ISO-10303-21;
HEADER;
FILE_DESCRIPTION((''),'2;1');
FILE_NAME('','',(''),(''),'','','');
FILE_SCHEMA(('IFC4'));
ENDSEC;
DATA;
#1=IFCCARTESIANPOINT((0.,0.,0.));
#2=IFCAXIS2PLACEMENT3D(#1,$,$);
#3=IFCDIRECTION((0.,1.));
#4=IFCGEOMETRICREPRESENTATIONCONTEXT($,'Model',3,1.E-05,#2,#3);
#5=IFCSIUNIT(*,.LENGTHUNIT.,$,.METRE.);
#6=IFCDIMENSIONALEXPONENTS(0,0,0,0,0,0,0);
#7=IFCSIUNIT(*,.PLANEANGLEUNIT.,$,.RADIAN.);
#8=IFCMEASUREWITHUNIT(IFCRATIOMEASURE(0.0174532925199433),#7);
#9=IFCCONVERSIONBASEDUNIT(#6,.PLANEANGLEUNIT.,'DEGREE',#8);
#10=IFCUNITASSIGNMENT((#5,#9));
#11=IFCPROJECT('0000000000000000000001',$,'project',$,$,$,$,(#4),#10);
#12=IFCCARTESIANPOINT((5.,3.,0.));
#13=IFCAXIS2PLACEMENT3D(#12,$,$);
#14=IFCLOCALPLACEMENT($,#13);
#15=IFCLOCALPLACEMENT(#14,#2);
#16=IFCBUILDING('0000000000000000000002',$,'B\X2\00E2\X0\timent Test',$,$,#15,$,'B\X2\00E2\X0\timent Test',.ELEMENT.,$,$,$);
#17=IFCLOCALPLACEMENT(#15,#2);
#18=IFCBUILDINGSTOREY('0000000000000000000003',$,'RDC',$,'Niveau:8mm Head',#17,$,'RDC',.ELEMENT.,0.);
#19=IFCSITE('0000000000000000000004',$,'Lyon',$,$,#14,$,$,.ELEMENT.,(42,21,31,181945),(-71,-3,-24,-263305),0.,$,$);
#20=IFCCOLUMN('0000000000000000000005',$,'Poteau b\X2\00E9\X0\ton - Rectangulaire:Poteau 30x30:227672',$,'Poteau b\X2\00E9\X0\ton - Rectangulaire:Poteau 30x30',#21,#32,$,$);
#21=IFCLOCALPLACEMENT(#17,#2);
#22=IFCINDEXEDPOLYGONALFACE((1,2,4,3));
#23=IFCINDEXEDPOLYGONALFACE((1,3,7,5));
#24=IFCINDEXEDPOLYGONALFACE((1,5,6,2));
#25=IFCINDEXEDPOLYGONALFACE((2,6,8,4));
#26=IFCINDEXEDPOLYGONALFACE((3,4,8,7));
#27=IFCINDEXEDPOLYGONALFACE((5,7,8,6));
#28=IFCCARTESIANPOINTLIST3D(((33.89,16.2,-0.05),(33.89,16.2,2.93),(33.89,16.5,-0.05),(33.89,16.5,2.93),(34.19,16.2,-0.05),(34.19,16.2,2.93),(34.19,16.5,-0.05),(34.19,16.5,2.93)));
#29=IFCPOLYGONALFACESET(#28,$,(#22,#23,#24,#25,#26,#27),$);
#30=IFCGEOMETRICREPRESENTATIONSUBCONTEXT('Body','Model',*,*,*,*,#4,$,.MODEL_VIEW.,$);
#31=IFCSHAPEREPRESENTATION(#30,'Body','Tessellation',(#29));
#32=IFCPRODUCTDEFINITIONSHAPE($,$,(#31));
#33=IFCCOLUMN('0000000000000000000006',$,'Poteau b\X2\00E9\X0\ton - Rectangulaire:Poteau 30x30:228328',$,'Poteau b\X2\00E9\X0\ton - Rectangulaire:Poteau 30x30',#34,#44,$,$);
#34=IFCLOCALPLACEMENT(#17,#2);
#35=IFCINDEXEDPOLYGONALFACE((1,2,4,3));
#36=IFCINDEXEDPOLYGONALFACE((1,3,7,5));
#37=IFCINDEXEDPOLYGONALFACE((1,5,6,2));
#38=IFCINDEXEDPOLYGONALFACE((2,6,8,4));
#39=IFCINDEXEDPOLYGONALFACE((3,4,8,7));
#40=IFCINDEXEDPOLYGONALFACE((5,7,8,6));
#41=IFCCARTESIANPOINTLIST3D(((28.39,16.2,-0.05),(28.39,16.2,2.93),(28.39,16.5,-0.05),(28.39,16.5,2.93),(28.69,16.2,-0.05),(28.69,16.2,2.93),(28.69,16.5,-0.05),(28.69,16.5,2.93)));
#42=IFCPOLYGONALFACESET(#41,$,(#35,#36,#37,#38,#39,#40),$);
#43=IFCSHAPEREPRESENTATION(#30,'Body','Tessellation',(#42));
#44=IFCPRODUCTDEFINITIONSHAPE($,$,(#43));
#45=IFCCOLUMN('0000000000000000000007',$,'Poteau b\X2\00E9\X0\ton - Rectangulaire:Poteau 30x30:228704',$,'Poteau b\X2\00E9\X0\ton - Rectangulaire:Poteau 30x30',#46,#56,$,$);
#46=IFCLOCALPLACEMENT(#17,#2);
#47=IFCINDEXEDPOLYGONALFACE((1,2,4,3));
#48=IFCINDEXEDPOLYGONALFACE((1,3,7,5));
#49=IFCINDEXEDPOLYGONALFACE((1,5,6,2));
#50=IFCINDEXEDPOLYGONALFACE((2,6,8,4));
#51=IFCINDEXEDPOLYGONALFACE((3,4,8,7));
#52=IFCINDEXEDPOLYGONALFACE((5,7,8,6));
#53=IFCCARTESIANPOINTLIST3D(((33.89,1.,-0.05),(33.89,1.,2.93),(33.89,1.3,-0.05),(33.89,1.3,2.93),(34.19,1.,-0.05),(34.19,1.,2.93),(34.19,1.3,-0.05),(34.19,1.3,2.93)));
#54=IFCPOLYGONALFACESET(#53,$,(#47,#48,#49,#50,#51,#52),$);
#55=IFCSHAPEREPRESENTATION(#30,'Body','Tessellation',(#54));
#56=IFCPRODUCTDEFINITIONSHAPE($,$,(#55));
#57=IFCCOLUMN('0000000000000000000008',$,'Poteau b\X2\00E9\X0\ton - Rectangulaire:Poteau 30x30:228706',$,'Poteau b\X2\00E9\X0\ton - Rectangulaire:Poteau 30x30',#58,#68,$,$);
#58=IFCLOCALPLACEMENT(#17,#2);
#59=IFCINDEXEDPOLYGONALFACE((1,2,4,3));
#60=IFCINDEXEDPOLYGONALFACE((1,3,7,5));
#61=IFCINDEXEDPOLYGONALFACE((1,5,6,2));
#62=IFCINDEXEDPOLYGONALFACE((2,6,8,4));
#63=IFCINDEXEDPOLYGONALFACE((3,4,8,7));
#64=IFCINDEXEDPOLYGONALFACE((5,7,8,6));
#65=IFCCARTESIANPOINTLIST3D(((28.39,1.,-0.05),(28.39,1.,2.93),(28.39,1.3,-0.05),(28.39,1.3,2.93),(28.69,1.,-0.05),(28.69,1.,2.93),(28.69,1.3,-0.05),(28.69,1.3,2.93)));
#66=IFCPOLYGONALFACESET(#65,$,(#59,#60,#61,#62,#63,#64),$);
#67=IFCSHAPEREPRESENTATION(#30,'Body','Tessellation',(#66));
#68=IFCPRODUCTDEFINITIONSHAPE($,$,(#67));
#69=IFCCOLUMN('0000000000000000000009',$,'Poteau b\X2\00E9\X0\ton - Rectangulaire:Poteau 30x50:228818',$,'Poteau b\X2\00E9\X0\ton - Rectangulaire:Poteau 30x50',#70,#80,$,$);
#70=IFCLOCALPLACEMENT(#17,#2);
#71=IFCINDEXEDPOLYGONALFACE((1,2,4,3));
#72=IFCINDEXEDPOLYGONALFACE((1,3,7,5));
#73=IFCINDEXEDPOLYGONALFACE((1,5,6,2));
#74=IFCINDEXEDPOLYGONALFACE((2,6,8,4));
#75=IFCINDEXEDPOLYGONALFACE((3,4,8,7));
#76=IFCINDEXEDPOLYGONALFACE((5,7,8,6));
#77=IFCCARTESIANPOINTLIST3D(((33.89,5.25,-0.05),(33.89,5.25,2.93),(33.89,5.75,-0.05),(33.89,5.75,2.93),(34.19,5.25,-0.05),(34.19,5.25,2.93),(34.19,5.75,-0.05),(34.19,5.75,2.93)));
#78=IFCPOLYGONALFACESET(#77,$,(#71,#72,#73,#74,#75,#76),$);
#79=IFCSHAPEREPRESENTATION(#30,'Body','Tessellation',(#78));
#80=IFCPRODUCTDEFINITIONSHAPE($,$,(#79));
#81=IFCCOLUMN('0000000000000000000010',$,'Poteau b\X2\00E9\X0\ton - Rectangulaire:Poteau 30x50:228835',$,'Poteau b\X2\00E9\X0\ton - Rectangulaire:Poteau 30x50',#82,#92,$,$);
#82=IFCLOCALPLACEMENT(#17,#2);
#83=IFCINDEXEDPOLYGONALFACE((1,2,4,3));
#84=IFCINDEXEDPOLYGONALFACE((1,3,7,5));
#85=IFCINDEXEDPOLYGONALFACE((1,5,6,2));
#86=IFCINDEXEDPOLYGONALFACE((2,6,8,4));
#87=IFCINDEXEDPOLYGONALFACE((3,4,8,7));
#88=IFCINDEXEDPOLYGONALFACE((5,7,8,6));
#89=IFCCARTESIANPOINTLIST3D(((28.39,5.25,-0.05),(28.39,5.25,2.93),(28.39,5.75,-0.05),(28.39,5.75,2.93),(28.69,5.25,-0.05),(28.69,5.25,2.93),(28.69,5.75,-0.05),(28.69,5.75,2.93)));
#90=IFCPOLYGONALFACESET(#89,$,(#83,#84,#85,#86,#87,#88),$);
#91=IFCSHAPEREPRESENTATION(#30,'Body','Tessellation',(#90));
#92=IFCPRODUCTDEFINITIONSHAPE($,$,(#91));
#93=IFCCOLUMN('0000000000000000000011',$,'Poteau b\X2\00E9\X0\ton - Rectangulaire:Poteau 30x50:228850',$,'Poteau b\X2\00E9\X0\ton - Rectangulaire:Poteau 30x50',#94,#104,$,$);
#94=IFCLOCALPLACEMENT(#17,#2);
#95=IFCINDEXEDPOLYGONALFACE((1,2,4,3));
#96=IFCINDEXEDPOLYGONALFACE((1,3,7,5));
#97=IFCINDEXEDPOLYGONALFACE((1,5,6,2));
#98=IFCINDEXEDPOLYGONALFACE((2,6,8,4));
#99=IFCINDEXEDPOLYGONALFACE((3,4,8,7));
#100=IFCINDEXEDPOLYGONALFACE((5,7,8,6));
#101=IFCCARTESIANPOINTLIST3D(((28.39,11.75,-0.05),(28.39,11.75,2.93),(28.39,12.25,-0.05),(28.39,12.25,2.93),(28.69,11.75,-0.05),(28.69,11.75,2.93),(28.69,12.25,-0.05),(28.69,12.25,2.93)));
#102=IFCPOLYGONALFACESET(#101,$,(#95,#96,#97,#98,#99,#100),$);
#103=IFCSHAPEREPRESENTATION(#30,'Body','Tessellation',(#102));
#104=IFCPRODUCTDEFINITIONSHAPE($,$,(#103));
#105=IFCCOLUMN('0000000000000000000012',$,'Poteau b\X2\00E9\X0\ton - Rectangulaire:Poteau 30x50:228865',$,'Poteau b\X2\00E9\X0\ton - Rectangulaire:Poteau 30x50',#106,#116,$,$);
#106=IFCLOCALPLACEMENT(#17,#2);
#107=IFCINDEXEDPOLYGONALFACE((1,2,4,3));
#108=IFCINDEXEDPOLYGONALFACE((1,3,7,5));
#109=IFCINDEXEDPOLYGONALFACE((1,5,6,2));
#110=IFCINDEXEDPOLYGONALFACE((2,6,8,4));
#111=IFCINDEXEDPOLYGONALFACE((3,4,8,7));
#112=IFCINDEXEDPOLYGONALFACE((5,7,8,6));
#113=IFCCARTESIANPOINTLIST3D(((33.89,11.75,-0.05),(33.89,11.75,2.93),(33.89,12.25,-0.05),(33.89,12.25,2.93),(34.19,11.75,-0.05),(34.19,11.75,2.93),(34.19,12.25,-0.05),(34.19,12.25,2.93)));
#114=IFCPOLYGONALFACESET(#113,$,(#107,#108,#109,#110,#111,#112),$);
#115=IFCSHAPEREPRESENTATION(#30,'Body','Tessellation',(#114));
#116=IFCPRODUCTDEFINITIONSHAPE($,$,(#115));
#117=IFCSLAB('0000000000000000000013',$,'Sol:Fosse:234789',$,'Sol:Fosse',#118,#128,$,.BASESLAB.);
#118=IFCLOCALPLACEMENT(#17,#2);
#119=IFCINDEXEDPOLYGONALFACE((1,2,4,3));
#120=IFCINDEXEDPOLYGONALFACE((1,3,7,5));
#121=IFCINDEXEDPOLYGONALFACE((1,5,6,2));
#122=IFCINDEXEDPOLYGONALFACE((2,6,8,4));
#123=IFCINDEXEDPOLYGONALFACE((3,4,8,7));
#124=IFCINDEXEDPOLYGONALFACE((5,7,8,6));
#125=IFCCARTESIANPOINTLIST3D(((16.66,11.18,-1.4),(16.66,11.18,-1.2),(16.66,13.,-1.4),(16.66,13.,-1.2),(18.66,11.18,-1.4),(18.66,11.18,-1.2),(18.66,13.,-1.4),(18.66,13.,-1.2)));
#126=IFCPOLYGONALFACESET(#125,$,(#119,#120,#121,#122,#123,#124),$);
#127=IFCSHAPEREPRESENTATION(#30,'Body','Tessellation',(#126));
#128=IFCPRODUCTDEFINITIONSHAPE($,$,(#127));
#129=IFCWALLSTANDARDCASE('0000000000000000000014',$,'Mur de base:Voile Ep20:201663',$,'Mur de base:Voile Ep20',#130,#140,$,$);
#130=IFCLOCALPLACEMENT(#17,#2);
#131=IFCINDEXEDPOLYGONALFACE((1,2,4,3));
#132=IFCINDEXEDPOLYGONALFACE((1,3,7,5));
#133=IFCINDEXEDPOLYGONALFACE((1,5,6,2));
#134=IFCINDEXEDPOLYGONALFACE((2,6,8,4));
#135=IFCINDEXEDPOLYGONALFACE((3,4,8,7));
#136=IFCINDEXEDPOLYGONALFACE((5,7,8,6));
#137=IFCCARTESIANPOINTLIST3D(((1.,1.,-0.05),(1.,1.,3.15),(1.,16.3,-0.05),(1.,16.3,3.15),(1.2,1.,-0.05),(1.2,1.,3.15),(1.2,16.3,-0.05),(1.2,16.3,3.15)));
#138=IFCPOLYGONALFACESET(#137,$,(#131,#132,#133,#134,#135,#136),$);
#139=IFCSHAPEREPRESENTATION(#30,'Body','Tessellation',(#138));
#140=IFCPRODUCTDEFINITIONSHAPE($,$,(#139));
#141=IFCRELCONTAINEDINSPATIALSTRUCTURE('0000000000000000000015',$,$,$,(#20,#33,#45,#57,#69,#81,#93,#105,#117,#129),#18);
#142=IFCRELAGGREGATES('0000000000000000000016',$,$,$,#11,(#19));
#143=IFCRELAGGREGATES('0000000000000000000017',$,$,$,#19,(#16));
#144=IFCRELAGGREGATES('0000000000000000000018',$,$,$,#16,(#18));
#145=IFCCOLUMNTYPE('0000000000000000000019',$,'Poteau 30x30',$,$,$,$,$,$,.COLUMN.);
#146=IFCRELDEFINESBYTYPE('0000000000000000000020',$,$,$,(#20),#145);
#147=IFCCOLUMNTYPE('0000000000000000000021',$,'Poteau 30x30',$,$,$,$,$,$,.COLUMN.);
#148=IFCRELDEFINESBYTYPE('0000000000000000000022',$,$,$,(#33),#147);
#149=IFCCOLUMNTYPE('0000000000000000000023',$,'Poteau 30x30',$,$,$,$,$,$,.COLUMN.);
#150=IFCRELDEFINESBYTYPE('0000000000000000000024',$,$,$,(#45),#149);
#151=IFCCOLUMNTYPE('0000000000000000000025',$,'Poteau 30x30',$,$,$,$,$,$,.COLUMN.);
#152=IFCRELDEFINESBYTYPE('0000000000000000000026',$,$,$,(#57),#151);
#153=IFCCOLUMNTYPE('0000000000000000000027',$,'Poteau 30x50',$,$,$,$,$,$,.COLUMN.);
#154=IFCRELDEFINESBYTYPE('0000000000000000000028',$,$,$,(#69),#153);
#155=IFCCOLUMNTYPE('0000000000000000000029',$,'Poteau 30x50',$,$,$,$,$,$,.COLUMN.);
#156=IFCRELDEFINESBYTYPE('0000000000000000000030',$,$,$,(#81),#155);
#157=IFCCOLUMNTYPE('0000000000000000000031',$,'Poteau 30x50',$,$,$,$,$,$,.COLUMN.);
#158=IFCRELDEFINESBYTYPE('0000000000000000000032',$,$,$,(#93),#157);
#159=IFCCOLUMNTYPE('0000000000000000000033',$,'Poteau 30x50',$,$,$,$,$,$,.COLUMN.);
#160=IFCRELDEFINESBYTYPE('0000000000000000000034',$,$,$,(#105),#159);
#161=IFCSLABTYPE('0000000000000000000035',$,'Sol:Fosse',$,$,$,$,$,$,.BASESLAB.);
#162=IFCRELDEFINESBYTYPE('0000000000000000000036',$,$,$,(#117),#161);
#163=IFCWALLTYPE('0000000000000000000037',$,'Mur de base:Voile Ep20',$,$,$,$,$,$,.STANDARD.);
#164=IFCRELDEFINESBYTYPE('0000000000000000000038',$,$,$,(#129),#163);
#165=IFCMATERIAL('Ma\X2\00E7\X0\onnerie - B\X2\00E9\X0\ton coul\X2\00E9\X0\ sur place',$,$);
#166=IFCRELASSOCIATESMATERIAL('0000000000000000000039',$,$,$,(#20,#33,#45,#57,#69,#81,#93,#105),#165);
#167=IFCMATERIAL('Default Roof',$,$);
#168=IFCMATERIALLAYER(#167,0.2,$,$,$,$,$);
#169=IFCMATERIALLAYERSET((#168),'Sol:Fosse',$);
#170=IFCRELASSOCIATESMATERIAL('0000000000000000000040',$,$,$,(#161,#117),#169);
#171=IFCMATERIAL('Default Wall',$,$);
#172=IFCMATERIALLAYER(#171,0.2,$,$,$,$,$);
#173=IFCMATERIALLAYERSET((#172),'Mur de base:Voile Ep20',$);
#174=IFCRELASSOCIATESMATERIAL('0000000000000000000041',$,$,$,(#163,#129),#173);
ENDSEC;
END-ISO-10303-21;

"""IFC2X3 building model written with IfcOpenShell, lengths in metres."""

from ifc_helpers import new_model, entity, si_unit, converted_unit, direction, frame, frame_2d, origin, origin_2d_with_axis, place, context, subcontext, project, spatial, rectangle, extrude, source, transform, mapped, material, layer, layer_set, layer_usage, type_object, type_shapes, element, save


model = new_model("IFC2X3")

# Units and contexts
model_context = context("Model", 3, precision=1e-05, world=origin(), true_north=direction((0.0, 1.0)))
body_context = subcontext(model_context, "Body", "Model", "MODEL_VIEW")
ifc_project = project(units=[si_unit("LENGTHUNIT", "METRE"), converted_unit("PLANEANGLEUNIT", "DEGREE", entity("IfcRatioMeasure", 0.0174532925199433), si_unit("PLANEANGLEUNIT", "RADIAN"), dimensions=[0, 0, 0, 0, 0, 0, 0])], contexts=[model_context])

# Site, building, storey
site_placement = place(None, frame((5.0, 3.0, 0.0)))
site = spatial("IfcSite", under=ifc_project, at=site_placement, Name="Lyon", CompositionType="ELEMENT", RefLatitude=(42, 21, 31, 181945), RefLongitude=(-71, -3, -24, -263305), RefElevation=0.0)
building_placement = place(site_placement, origin())
building = spatial("IfcBuilding", under=site, at=building_placement, Name="Bâtiment Test", LongName="Bâtiment Test", CompositionType="ELEMENT")
storey_placement = place(building_placement, origin())
storey = spatial("IfcBuildingStorey", under=building, at=storey_placement, Name="RDC", ObjectType="Niveau:8mm Head", LongName="RDC", CompositionType="ELEMENT", Elevation=0.0)

# Columns
ifc_material_1 = material(Name="Maçonnerie - Béton coulé sur place")
column_type_1 = type_object("IfcColumnType", Name="Poteau 30x30", PredefinedType="COLUMN")
shared_shape_1 = source(origin(), body_context, "Body", "SweptSolid", [
    extrude(rectangle(XDim=0.3, YDim=0.3, at=origin_2d_with_axis()), frame((34.04, 16.35, -0.05), z_axis=(0.0, 0.0, 1.0), x_axis=(0.0, -1.0, 0.0)), (0.0, 0.0, 1.0), 2.98),
])
type_shapes(column_type_1, [shared_shape_1])
column_1_placement = place(storey_placement, origin())
element("IfcColumn", 1, at=column_1_placement, inside=storey, type_object=column_type_1, material=ifc_material_1, Name="Poteau béton - Rectangulaire:Poteau 30x30:227672", ObjectType="Poteau béton - Rectangulaire:Poteau 30x30", context=body_context, shape_type="MappedRepresentation", body=[
    mapped(shared_shape_1, transform((0.0, 0.0, 0.0), scale=1.0)),
])
column_type_2 = type_object("IfcColumnType", Name="Poteau 30x30", PredefinedType="COLUMN")
shared_shape_2 = source(origin(), body_context, "Body", "SweptSolid", [
    extrude(rectangle(XDim=0.3, YDim=0.3, at=origin_2d_with_axis()), frame((28.54, 16.35, -0.05), z_axis=(0.0, 0.0, 1.0), x_axis=(0.0, -1.0, 0.0)), (0.0, 0.0, 1.0), 2.98),
])
type_shapes(column_type_2, [shared_shape_2])
column_2_placement = place(storey_placement, origin())
element("IfcColumn", 2, at=column_2_placement, inside=storey, type_object=column_type_2, material=ifc_material_1, Name="Poteau béton - Rectangulaire:Poteau 30x30:228328", ObjectType="Poteau béton - Rectangulaire:Poteau 30x30", context=body_context, shape_type="MappedRepresentation", body=[
    mapped(shared_shape_2, transform((0.0, 0.0, 0.0), scale=1.0)),
])
column_type_3 = type_object("IfcColumnType", Name="Poteau 30x30", PredefinedType="COLUMN")
shared_shape_3 = source(origin(), body_context, "Body", "SweptSolid", [
    extrude(rectangle(XDim=0.3, YDim=0.3, at=frame_2d((0.0, 0.0), x_axis=(1.0, 0.0))), frame((34.04, 1.15, -0.05), z_axis=(0.0, 0.0, 1.0), x_axis=(0.0, -1.0, 0.0)), (0.0, 0.0, 1.0), 2.98),
])
type_shapes(column_type_3, [shared_shape_3])
column_3_placement = place(storey_placement, origin())
element("IfcColumn", 3, at=column_3_placement, inside=storey, type_object=column_type_3, material=ifc_material_1, Name="Poteau béton - Rectangulaire:Poteau 30x30:228704", ObjectType="Poteau béton - Rectangulaire:Poteau 30x30", context=body_context, shape_type="MappedRepresentation", body=[
    mapped(shared_shape_3, transform((0.0, 0.0, 0.0), scale=1.0)),
])
column_type_4 = type_object("IfcColumnType", Name="Poteau 30x30", PredefinedType="COLUMN")
shared_shape_4 = source(origin(), body_context, "Body", "SweptSolid", [
    extrude(rectangle(XDim=0.3, YDim=0.3, at=frame_2d((0.0, 0.0), x_axis=(1.0, 0.0))), frame((28.54, 1.15, -0.05), z_axis=(0.0, 0.0, 1.0), x_axis=(0.0, -1.0, 0.0)), (0.0, 0.0, 1.0), 2.98),
])
type_shapes(column_type_4, [shared_shape_4])
column_4_placement = place(storey_placement, origin())
element("IfcColumn", 4, at=column_4_placement, inside=storey, type_object=column_type_4, material=ifc_material_1, Name="Poteau béton - Rectangulaire:Poteau 30x30:228706", ObjectType="Poteau béton - Rectangulaire:Poteau 30x30", context=body_context, shape_type="MappedRepresentation", body=[
    mapped(shared_shape_4, transform((0.0, 0.0, 0.0), scale=1.0)),
])
column_type_5 = type_object("IfcColumnType", Name="Poteau 30x50", PredefinedType="COLUMN")
shared_shape_5 = source(origin(), body_context, "Body", "SweptSolid", [
    extrude(rectangle(XDim=0.5, YDim=0.3, at=origin_2d_with_axis()), frame((34.04, 5.5, -0.05), z_axis=(0.0, 0.0, 1.0), x_axis=(0.0, -1.0, 0.0)), (0.0, 0.0, 1.0), 2.98),
])
type_shapes(column_type_5, [shared_shape_5])
column_5_placement = place(storey_placement, origin())
element("IfcColumn", 5, at=column_5_placement, inside=storey, type_object=column_type_5, material=ifc_material_1, Name="Poteau béton - Rectangulaire:Poteau 30x50:228818", ObjectType="Poteau béton - Rectangulaire:Poteau 30x50", context=body_context, shape_type="MappedRepresentation", body=[
    mapped(shared_shape_5, transform((0.0, 0.0, 0.0), scale=1.0)),
])
column_type_6 = type_object("IfcColumnType", Name="Poteau 30x50", PredefinedType="COLUMN")
shared_shape_6 = source(origin(), body_context, "Body", "SweptSolid", [
    extrude(rectangle(XDim=0.5, YDim=0.3, at=origin_2d_with_axis()), frame((28.54, 5.5, -0.05), z_axis=(0.0, 0.0, 1.0), x_axis=(0.0, -1.0, 0.0)), (0.0, 0.0, 1.0), 2.98),
])
type_shapes(column_type_6, [shared_shape_6])
column_6_placement = place(storey_placement, origin())
element("IfcColumn", 6, at=column_6_placement, inside=storey, type_object=column_type_6, material=ifc_material_1, Name="Poteau béton - Rectangulaire:Poteau 30x50:228835", ObjectType="Poteau béton - Rectangulaire:Poteau 30x50", context=body_context, shape_type="MappedRepresentation", body=[
    mapped(shared_shape_6, transform((0.0, 0.0, 0.0), scale=1.0)),
])
column_type_7 = type_object("IfcColumnType", Name="Poteau 30x50", PredefinedType="COLUMN")
shared_shape_7 = source(origin(), body_context, "Body", "SweptSolid", [
    extrude(rectangle(XDim=0.5, YDim=0.3, at=origin_2d_with_axis()), frame((28.54, 12.0, -0.05), z_axis=(0.0, 0.0, 1.0), x_axis=(0.0, -1.0, 0.0)), (0.0, 0.0, 1.0), 2.98),
])
type_shapes(column_type_7, [shared_shape_7])
column_7_placement = place(storey_placement, origin())
element("IfcColumn", 7, at=column_7_placement, inside=storey, type_object=column_type_7, material=ifc_material_1, Name="Poteau béton - Rectangulaire:Poteau 30x50:228850", ObjectType="Poteau béton - Rectangulaire:Poteau 30x50", context=body_context, shape_type="MappedRepresentation", body=[
    mapped(shared_shape_7, transform((0.0, 0.0, 0.0), scale=1.0)),
])
column_type_8 = type_object("IfcColumnType", Name="Poteau 30x50", PredefinedType="COLUMN")
shared_shape_8 = source(origin(), body_context, "Body", "SweptSolid", [
    extrude(rectangle(XDim=0.5, YDim=0.3, at=origin_2d_with_axis()), frame((34.04, 12.0, -0.05), z_axis=(0.0, 0.0, 1.0), x_axis=(0.0, -1.0, 0.0)), (0.0, 0.0, 1.0), 2.98),
])
type_shapes(column_type_8, [shared_shape_8])
column_8_placement = place(storey_placement, origin())
element("IfcColumn", 8, at=column_8_placement, inside=storey, type_object=column_type_8, material=ifc_material_1, Name="Poteau béton - Rectangulaire:Poteau 30x50:228865", ObjectType="Poteau béton - Rectangulaire:Poteau 30x50", context=body_context, shape_type="MappedRepresentation", body=[
    mapped(shared_shape_8, transform((0.0, 0.0, 0.0), scale=1.0)),
])

# Shared definitions
ifc_material_2 = material(Name="Default Roof")

# Slab
ifc_layer_1 = layer(ifc_material_2, 0.2)
ifc_layer_set_1 = layer_set([ifc_layer_1], Name="Sol:Fosse")
ifc_layer_usage_1 = layer_usage(ifc_layer_set_1, "AXIS3", "POSITIVE", 0.0)
slab_type_1 = type_object("IfcSlabType", Name="Sol:Fosse", PredefinedType="BASESLAB", material=ifc_layer_set_1)
slab_1_placement = place(storey_placement, origin())
element("IfcSlab", 9, at=slab_1_placement, inside=storey, type_object=slab_type_1, material=ifc_layer_usage_1, Name="Sol:Fosse:234789", ObjectType="Sol:Fosse", PredefinedType="BASESLAB", context=body_context, shape_type="SweptSolid", body=[
    extrude(rectangle(XDim=1.82, YDim=2.0, at=frame_2d((0.0, 0.0), x_axis=(1.0, 0.0))), frame((17.66, 12.09, -1.2), z_axis=(0.0, 0.0, -1.0), x_axis=(0.0, 1.0, 0.0)), (0.0, 0.0, 1.0), 0.2),
])

# Wall
ifc_material_3 = material(Name="Default Wall")
ifc_layer_2 = layer(ifc_material_3, 0.2)
ifc_layer_set_2 = layer_set([ifc_layer_2], Name="Mur de base:Voile Ep20")
ifc_layer_usage_2 = layer_usage(ifc_layer_set_2, "AXIS2", "POSITIVE", -0.1)
wall_type_1 = type_object("IfcWallType", Name="Mur de base:Voile Ep20", PredefinedType="STANDARD", material=ifc_layer_set_2)
wall_1_placement = place(storey_placement, frame((1.1, 16.3, -0.05), z_axis=(0.0, 0.0, 1.0), x_axis=(0.0, -1.0, 0.0)))
element("IfcWallStandardCase", 10, at=wall_1_placement, inside=storey, type_object=wall_type_1, material=ifc_layer_usage_2, Name="Mur de base:Voile Ep20:201663", ObjectType="Mur de base:Voile Ep20", context=body_context, shape_type="SweptSolid", body=[
    extrude(rectangle(XDim=15.3, YDim=0.2, at=frame_2d((7.65, 0.0), x_axis=(-1.0, 0.0))), origin(), (0.0, 0.0, 1.0), 3.2),
])

save(model, "model.ifc")
